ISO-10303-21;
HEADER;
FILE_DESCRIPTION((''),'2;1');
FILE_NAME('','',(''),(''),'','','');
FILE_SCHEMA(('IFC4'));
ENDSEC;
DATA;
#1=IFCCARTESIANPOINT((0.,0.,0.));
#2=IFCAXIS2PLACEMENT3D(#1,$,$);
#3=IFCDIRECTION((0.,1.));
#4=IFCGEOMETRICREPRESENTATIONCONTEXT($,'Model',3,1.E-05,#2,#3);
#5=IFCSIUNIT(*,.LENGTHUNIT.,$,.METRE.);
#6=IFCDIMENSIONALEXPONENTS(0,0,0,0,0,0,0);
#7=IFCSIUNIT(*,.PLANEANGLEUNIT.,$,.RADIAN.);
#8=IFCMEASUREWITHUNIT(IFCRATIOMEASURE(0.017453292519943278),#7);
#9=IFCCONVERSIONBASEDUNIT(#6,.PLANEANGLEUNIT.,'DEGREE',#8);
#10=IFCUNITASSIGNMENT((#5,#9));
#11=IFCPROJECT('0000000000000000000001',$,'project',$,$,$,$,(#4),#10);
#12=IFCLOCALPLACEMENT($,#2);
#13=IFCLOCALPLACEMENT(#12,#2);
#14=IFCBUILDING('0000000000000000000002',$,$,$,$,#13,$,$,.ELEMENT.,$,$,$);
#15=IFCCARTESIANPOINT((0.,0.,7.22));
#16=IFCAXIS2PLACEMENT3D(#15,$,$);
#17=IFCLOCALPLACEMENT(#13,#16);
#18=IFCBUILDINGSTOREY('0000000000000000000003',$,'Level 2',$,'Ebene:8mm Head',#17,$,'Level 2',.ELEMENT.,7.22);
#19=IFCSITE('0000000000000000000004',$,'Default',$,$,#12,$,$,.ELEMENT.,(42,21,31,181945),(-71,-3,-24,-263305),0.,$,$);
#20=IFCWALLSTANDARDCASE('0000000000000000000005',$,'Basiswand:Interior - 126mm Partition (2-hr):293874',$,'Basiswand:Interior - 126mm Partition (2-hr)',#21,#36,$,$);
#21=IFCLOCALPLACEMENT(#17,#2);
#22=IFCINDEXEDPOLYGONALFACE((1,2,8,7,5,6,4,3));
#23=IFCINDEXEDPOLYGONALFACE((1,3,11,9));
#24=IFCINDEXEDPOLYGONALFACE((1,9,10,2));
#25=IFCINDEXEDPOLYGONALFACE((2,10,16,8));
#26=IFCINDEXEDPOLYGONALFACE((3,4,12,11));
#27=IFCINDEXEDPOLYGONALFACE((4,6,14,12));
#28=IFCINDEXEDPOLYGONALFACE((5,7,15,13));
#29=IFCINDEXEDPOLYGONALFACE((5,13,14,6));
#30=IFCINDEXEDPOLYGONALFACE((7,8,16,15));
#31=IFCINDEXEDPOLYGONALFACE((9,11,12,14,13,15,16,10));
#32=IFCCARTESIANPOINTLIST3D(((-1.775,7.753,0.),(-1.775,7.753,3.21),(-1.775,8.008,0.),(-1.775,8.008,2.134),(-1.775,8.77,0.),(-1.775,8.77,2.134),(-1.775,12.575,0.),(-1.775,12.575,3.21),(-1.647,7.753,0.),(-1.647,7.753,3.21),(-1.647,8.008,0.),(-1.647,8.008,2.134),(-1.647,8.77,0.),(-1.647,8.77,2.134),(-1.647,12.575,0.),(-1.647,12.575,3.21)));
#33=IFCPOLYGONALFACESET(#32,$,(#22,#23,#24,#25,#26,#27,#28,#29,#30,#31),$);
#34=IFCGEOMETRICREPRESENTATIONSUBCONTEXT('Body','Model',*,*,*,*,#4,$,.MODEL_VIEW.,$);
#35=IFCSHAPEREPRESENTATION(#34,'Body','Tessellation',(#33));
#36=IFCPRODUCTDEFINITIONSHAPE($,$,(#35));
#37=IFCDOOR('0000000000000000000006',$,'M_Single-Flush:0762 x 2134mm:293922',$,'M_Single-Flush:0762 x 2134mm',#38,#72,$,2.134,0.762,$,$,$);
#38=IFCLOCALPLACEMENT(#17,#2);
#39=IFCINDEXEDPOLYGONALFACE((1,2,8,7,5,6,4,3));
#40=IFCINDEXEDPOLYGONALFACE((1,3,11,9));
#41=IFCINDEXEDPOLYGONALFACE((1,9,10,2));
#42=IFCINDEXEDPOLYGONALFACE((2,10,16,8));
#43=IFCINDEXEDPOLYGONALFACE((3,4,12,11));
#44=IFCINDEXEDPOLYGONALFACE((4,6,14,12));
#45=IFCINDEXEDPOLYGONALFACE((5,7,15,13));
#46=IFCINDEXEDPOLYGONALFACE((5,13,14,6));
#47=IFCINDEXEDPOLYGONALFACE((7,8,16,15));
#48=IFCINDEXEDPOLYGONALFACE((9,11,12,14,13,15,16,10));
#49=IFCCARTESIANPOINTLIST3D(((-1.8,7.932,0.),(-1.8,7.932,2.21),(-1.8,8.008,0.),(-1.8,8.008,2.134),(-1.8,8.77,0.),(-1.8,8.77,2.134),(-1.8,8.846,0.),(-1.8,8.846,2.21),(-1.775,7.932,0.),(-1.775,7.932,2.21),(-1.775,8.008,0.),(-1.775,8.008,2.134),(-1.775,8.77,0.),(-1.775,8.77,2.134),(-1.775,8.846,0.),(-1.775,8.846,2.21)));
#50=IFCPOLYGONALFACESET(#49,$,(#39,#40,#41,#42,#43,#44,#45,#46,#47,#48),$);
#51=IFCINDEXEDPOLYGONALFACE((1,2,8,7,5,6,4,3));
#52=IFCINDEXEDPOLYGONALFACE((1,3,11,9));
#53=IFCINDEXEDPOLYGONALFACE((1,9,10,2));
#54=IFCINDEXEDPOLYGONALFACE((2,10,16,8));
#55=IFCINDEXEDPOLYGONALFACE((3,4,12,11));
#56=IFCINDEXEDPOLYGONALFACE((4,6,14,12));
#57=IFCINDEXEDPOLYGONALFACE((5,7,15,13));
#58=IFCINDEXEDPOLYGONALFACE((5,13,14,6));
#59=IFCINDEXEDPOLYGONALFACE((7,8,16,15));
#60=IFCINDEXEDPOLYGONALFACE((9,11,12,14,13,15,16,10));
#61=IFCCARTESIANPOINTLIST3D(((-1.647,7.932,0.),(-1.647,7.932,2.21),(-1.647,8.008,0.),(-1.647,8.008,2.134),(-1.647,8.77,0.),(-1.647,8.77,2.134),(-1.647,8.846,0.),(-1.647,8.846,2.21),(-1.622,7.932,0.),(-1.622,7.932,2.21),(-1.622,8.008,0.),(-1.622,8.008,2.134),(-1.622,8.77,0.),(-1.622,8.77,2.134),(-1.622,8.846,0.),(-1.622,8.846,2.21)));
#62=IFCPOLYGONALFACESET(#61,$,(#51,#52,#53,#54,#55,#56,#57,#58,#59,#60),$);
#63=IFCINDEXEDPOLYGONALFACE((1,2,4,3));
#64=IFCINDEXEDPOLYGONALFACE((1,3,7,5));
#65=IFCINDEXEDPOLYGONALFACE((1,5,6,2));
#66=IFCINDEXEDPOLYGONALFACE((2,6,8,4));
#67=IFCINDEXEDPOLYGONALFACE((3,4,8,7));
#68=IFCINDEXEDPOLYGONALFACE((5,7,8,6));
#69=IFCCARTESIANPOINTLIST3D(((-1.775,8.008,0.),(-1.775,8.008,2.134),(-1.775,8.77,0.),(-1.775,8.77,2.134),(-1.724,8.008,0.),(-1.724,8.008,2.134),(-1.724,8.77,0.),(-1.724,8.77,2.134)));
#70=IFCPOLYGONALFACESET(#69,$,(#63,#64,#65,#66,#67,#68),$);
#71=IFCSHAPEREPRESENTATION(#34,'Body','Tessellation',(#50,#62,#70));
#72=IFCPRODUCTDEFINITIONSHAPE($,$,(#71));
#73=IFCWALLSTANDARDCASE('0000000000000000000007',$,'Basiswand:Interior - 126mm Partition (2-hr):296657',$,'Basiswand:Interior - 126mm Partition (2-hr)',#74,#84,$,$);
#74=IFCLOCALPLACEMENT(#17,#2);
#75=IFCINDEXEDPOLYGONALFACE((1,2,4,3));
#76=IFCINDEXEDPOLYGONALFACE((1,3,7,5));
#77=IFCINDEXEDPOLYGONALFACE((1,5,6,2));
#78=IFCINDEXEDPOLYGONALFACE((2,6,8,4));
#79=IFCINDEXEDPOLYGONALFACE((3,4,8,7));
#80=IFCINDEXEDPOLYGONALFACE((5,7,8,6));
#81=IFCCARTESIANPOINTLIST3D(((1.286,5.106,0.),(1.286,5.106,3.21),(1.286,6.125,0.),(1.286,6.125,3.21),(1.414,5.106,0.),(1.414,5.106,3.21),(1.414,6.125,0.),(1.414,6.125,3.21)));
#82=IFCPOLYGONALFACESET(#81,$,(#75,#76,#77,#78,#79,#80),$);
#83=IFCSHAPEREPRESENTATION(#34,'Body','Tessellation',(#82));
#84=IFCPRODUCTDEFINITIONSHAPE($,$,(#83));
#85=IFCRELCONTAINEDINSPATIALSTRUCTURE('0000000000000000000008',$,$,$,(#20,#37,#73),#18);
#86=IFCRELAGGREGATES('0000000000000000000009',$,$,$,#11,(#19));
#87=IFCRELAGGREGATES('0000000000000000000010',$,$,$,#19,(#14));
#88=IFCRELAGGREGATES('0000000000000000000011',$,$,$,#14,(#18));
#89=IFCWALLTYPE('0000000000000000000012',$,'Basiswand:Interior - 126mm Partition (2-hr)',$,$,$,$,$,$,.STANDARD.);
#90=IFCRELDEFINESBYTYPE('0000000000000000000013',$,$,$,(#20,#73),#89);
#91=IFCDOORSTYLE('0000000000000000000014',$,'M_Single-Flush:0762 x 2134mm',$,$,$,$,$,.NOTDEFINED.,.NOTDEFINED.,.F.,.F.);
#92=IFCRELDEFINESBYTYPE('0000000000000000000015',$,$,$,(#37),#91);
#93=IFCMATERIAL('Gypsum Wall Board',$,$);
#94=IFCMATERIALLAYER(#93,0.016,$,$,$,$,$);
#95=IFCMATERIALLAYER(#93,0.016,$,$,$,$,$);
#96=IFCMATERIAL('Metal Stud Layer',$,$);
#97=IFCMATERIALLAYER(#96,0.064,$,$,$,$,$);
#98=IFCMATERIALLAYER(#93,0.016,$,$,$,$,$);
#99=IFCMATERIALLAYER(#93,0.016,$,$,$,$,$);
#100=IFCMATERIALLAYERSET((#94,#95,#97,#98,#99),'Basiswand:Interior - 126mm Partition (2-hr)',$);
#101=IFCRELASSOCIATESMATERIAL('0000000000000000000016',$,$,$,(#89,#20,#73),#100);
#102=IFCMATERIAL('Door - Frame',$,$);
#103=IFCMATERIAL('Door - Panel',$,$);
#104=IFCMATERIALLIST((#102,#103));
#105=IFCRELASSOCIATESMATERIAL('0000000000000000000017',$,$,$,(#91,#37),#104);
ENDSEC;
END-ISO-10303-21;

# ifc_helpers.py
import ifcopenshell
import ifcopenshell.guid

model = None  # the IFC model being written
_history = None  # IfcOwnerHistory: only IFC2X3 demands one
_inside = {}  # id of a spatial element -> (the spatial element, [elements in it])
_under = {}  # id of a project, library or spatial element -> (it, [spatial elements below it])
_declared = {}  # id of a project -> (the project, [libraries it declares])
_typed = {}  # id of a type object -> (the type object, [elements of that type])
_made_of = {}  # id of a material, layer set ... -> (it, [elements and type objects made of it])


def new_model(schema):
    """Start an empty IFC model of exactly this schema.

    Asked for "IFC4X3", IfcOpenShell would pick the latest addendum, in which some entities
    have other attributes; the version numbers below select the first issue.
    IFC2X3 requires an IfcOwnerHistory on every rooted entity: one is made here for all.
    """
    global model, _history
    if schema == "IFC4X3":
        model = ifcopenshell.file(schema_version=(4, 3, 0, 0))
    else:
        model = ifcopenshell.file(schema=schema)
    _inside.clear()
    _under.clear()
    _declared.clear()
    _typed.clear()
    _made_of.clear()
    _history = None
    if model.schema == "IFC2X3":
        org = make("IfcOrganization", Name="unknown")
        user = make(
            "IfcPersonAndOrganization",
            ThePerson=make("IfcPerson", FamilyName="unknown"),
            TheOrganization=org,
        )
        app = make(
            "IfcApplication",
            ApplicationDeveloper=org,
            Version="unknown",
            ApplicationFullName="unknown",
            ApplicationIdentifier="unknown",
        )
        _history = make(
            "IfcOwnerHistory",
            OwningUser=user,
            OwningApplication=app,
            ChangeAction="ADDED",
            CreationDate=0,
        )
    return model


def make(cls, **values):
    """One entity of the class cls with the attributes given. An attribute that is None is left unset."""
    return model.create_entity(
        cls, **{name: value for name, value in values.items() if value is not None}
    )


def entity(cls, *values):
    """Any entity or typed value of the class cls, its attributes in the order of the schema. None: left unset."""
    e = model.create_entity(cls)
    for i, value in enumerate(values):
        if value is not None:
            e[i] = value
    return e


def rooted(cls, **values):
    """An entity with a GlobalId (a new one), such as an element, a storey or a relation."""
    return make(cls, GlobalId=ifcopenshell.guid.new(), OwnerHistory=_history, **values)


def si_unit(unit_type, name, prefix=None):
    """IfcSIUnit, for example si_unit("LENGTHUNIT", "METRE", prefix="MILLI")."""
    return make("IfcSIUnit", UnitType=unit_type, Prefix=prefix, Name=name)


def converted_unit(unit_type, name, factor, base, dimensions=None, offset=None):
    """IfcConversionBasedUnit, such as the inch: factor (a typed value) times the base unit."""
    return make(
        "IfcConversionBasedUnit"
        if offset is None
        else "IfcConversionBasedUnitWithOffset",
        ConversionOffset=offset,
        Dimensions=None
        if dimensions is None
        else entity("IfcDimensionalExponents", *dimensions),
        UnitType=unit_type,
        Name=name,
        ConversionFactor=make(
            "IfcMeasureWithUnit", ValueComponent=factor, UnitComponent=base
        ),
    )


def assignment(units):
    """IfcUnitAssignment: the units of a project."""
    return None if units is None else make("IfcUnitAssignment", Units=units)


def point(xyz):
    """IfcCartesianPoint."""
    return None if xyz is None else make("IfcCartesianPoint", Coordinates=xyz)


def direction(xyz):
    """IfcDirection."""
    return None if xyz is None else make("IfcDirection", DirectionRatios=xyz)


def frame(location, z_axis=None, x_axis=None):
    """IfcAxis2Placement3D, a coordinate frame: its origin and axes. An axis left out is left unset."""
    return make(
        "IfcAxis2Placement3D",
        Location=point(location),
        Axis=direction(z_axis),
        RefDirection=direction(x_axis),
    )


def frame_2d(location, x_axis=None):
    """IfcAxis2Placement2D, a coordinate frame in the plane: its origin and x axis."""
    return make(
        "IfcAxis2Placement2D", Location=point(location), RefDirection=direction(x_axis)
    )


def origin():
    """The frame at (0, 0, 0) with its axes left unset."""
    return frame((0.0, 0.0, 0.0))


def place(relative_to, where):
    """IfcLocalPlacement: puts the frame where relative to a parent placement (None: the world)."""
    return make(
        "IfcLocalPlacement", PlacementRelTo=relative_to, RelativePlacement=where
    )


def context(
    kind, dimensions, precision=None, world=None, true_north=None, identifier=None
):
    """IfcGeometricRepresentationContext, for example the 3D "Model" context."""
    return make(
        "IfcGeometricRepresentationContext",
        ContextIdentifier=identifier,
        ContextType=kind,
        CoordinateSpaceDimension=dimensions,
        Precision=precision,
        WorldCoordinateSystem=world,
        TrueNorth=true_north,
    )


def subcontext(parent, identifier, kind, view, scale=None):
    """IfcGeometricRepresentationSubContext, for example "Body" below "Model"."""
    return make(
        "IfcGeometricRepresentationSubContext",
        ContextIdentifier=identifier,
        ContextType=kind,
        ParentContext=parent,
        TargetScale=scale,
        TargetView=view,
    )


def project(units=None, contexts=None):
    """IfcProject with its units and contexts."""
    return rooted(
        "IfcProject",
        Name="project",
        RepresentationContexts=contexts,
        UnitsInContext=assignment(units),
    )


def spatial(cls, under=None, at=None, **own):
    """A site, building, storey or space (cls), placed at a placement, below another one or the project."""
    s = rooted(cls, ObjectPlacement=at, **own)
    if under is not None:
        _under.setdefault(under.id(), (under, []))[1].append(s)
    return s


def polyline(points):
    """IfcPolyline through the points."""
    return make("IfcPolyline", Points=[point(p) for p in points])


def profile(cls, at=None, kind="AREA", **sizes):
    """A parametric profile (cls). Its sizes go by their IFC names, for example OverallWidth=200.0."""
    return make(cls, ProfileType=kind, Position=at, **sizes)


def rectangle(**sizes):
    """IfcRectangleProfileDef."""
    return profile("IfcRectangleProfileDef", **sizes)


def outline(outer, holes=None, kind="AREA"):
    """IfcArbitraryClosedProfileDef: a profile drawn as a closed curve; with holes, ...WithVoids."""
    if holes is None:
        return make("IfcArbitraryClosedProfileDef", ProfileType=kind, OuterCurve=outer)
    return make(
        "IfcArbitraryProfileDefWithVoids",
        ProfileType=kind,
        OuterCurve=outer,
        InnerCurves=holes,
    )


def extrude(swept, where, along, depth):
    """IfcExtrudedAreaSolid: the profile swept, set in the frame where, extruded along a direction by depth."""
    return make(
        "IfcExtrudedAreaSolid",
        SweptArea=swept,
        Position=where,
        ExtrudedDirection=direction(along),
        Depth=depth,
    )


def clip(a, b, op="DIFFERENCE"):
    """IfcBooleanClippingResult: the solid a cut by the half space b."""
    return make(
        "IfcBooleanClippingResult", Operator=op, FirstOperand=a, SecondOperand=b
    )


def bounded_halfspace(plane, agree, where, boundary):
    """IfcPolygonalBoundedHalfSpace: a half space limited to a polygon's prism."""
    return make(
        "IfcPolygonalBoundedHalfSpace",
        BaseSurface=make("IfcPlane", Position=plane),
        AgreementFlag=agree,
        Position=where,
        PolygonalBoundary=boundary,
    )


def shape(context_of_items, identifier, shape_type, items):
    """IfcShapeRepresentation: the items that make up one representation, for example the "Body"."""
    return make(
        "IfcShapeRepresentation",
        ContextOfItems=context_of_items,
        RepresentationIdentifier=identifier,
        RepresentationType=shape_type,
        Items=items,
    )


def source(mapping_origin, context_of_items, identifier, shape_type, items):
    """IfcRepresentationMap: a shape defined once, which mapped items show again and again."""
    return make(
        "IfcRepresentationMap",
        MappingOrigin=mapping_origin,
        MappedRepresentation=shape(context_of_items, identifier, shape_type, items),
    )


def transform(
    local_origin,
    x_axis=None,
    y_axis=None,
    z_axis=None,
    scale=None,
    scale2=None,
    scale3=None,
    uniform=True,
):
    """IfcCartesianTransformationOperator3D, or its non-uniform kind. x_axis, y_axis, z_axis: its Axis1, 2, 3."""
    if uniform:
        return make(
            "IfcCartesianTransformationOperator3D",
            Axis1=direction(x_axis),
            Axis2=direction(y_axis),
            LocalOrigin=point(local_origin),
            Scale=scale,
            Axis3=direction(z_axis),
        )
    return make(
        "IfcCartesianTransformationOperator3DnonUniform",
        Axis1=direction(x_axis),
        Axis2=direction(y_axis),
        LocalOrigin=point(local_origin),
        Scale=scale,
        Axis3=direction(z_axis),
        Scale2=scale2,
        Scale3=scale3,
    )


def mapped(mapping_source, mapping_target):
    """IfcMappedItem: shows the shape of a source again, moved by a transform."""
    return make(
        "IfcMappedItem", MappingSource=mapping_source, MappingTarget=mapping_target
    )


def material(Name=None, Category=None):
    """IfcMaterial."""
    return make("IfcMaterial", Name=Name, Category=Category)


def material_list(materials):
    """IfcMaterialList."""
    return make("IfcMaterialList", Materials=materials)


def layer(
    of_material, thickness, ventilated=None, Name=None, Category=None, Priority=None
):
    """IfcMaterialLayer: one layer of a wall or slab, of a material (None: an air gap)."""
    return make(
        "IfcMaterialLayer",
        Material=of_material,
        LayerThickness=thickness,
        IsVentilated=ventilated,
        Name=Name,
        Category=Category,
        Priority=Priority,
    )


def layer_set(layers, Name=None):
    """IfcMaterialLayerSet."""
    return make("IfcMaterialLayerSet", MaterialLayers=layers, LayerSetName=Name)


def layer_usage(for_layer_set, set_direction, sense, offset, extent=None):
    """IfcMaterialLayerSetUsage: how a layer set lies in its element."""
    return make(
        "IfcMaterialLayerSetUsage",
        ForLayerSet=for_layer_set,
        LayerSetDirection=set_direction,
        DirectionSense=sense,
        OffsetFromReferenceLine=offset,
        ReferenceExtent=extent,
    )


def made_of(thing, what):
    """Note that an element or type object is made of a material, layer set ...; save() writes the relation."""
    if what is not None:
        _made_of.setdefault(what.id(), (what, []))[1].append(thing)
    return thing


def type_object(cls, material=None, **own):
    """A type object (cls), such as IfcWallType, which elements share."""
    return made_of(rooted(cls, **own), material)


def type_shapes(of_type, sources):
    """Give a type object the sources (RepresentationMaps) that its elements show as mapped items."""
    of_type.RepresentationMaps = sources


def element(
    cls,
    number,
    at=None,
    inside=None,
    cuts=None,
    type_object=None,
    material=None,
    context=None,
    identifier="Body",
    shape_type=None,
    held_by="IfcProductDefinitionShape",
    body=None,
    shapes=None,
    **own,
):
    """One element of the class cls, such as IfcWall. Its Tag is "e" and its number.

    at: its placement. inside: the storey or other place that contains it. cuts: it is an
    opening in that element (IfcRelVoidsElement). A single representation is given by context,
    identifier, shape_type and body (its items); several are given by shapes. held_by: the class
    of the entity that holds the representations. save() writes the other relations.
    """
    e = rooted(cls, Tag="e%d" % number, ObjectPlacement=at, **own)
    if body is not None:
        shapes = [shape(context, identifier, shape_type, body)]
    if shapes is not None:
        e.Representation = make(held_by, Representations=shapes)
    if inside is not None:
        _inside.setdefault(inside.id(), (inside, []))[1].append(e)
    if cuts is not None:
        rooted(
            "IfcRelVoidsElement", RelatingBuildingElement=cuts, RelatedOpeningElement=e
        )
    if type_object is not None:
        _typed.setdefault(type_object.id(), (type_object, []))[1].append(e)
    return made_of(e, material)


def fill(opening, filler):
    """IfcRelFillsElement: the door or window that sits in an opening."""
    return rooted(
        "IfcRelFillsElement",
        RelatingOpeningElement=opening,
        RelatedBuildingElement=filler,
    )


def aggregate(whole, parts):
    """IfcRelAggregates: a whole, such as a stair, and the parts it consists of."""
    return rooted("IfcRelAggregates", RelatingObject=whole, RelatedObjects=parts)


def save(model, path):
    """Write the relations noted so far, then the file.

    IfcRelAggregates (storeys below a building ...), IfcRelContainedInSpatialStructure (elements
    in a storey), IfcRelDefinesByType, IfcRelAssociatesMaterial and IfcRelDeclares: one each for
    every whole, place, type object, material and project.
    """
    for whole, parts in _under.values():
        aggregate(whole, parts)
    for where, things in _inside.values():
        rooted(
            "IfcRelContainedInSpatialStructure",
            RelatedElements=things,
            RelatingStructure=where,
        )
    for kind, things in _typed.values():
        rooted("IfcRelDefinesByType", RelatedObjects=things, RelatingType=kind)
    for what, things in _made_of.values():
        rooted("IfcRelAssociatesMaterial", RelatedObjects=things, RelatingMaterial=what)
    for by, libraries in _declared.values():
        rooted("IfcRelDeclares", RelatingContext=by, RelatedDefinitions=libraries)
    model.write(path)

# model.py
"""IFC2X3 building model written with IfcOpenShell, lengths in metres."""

from ifc_helpers import new_model, entity, si_unit, converted_unit, direction, frame, frame_2d, origin, place, context, subcontext, project, spatial, polyline, rectangle, outline, extrude, clip, bounded_halfspace, source, transform, mapped, material, material_list, layer, layer_set, layer_usage, type_object, type_shapes, element, fill, save


model = new_model("IFC2X3")

# Units and contexts
model_context = context("Model", 3, precision=1e-05, world=origin(), true_north=direction((0.0, 1.0)))
body_context = subcontext(model_context, "Body", "Model", "MODEL_VIEW")
ifc_project = project(units=[si_unit("LENGTHUNIT", "METRE"), converted_unit("PLANEANGLEUNIT", "DEGREE", entity("IfcRatioMeasure", 0.017453292519943278), si_unit("PLANEANGLEUNIT", "RADIAN"), dimensions=[0, 0, 0, 0, 0, 0, 0])], contexts=[model_context])

# Site, building, storey
site_placement = place(None, origin())
site = spatial("IfcSite", under=ifc_project, at=site_placement, Name="Default", CompositionType="ELEMENT", RefLatitude=(42, 21, 31, 181945), RefLongitude=(-71, -3, -24, -263305), RefElevation=0.0)
building_placement = place(site_placement, origin())
building = spatial("IfcBuilding", under=site, at=building_placement, CompositionType="ELEMENT")
storey_placement = place(building_placement, frame((0.0, 0.0, 7.22)))
storey = spatial("IfcBuildingStorey", under=building, at=storey_placement, Name="Level 2", ObjectType="Ebene:8mm Head", LongName="Level 2", CompositionType="ELEMENT", Elevation=7.22)

# Shared definitions
ifc_material_1 = material(Name="Gypsum Wall Board")
ifc_layer_1 = layer(ifc_material_1, 0.016)
ifc_layer_2 = layer(ifc_material_1, 0.016)
ifc_material_2 = material(Name="Metal Stud Layer")
ifc_layer_3 = layer(ifc_material_2, 0.064)
ifc_layer_4 = layer(ifc_material_1, 0.016)
ifc_layer_5 = layer(ifc_material_1, 0.016)
ifc_layer_set = layer_set([ifc_layer_1, ifc_layer_2, ifc_layer_3, ifc_layer_4, ifc_layer_5], Name="Basiswand:Interior - 126mm Partition (2-hr)")
ifc_layer_usage_1 = layer_usage(ifc_layer_set, "AXIS2", "NEGATIVE", 0.064)
wall_type = type_object("IfcWallType", Name="Basiswand:Interior - 126mm Partition (2-hr)", PredefinedType="STANDARD", material=ifc_layer_set)
ifc_material_3 = material(Name="Door - Frame")
ifc_material_4 = material(Name="Door - Panel")
ifc_material_list = material_list([ifc_material_3, ifc_material_4])
door_style_1 = type_object("IfcDoorStyle", Name="M_Single-Flush:0762 x 2134mm", ConstructionType="NOTDEFINED", OperationType="NOTDEFINED", ParameterTakesPrecedence=False, Sizeable=False, material=ifc_material_list)
shared_shape_1 = source(origin(), body_context, "Body", "SweptSolid", [
    extrude(outline(polyline([(-0.457, -1.124), (0.457, -1.124), (0.457, 1.086), (0.381, 1.086), (0.381, -1.048), (-0.381, -1.048), (-0.381, 1.086), (-0.457, 1.086), (-0.457, -1.124)])), frame((0.381, 0.153, 1.086), z_axis=(0.0, -1.0, 0.0), x_axis=(-1.0, 0.0, 0.0)), (0.0, 0.0, 1.0), 0.025),
    extrude(outline(polyline([(-1.124, -0.457), (1.086, -0.457), (1.086, -0.381), (-1.048, -0.381), (-1.048, 0.381), (1.086, 0.381), (1.086, 0.457), (-1.124, 0.457), (-1.124, -0.457)])), frame((0.381, 0.0, 1.086), z_axis=(0.0, -1.0, 0.0), x_axis=(0.0, 0.0, -1.0)), (0.0, 0.0, 1.0), 0.025),
    extrude(rectangle(XDim=0.762, YDim=0.051, at=frame_2d((0.0, 0.0), x_axis=(1.0, 0.0))), frame((0.381, 0.1025, 0.0)), (0.0, 0.0, 1.0), 2.134),
])
type_shapes(door_style_1, [shared_shape_1])

# Shared definitions
ifc_layer_usage_2 = layer_usage(ifc_layer_set, "AXIS2", "POSITIVE", -0.064)

# Wall, opening, door
wall_1_placement = place(storey_placement, frame((-1.711, 7.753, 0.0), z_axis=(0.0, 0.0, 1.0), x_axis=(0.0, 1.0, 0.0)))
wall_1 = element("IfcWallStandardCase", 1, at=wall_1_placement, inside=storey, type_object=wall_type, material=ifc_layer_usage_1, Name="Basiswand:Interior - 126mm Partition (2-hr):293874", ObjectType="Basiswand:Interior - 126mm Partition (2-hr)", context=body_context, shape_type="Clipping", body=[
    clip(extrude(rectangle(XDim=4.822, YDim=0.128, at=frame_2d((2.411, 0.0), x_axis=(-1.0, 0.0))), origin(), (0.0, 0.0, 1.0), 3.21), bounded_halfspace(frame((0.0, -0.064, 3.21), z_axis=(0.0, 0.0, -1.0), x_axis=(1.0, 0.0, 0.0)), True, frame((0.0, -0.064, 3.21)), polyline([(0.0, 0.0), (4.822, 0.0), (4.822, 0.128), (0.0, 0.128), (0.0, 0.0)]))),
])
opening_1_placement = place(wall_1_placement, frame((0.255, -0.064, 0.0)))
opening_1 = element("IfcOpeningElement", 2, at=opening_1_placement, cuts=wall_1, ObjectType="Opening", context=body_context, shape_type="SweptSolid", body=[
    extrude(rectangle(XDim=0.762, YDim=2.134, at=frame_2d((1.067, 0.381), x_axis=(0.0, -1.0))), frame((0.0, 0.0, 0.0), z_axis=(0.0, 1.0, 0.0), x_axis=(0.0, 0.0, 1.0)), (0.0, 0.0, 1.0), 0.128),
])
door_1_placement = place(opening_1_placement, origin())
door_1 = element("IfcDoor", 3, at=door_1_placement, inside=storey, type_object=door_style_1, material=ifc_material_list, Name="M_Single-Flush:0762 x 2134mm:293922", ObjectType="M_Single-Flush:0762 x 2134mm", OverallHeight=2.134, OverallWidth=0.762, context=body_context, shape_type="MappedRepresentation", body=[
    mapped(shared_shape_1, transform((0.0, 0.0, 0.0), scale=1.0)),
])
fill(opening_1, door_1)

# Wall
wall_2_placement = place(storey_placement, frame((1.35, 5.106, 0.0), z_axis=(0.0, 0.0, 1.0), x_axis=(0.0, 1.0, 0.0)))
element("IfcWallStandardCase", 4, at=wall_2_placement, inside=storey, type_object=wall_type, material=ifc_layer_usage_2, Name="Basiswand:Interior - 126mm Partition (2-hr):296657", ObjectType="Basiswand:Interior - 126mm Partition (2-hr)", context=body_context, shape_type="Clipping", body=[
    clip(extrude(rectangle(XDim=1.019, YDim=0.128, at=frame_2d((0.5095, 0.0), x_axis=(-1.0, 0.0))), origin(), (0.0, 0.0, 1.0), 3.21), bounded_halfspace(frame((0.0, -0.064, 3.21), z_axis=(0.0, 0.0, -1.0), x_axis=(1.0, 0.0, 0.0)), True, frame((0.0, -0.064, 3.21)), polyline([(0.0, 0.0), (1.019, 0.0), (1.019, 0.128), (0.0, 0.128), (0.0, 0.0)]))),
])

save(model, "model.ifc")
